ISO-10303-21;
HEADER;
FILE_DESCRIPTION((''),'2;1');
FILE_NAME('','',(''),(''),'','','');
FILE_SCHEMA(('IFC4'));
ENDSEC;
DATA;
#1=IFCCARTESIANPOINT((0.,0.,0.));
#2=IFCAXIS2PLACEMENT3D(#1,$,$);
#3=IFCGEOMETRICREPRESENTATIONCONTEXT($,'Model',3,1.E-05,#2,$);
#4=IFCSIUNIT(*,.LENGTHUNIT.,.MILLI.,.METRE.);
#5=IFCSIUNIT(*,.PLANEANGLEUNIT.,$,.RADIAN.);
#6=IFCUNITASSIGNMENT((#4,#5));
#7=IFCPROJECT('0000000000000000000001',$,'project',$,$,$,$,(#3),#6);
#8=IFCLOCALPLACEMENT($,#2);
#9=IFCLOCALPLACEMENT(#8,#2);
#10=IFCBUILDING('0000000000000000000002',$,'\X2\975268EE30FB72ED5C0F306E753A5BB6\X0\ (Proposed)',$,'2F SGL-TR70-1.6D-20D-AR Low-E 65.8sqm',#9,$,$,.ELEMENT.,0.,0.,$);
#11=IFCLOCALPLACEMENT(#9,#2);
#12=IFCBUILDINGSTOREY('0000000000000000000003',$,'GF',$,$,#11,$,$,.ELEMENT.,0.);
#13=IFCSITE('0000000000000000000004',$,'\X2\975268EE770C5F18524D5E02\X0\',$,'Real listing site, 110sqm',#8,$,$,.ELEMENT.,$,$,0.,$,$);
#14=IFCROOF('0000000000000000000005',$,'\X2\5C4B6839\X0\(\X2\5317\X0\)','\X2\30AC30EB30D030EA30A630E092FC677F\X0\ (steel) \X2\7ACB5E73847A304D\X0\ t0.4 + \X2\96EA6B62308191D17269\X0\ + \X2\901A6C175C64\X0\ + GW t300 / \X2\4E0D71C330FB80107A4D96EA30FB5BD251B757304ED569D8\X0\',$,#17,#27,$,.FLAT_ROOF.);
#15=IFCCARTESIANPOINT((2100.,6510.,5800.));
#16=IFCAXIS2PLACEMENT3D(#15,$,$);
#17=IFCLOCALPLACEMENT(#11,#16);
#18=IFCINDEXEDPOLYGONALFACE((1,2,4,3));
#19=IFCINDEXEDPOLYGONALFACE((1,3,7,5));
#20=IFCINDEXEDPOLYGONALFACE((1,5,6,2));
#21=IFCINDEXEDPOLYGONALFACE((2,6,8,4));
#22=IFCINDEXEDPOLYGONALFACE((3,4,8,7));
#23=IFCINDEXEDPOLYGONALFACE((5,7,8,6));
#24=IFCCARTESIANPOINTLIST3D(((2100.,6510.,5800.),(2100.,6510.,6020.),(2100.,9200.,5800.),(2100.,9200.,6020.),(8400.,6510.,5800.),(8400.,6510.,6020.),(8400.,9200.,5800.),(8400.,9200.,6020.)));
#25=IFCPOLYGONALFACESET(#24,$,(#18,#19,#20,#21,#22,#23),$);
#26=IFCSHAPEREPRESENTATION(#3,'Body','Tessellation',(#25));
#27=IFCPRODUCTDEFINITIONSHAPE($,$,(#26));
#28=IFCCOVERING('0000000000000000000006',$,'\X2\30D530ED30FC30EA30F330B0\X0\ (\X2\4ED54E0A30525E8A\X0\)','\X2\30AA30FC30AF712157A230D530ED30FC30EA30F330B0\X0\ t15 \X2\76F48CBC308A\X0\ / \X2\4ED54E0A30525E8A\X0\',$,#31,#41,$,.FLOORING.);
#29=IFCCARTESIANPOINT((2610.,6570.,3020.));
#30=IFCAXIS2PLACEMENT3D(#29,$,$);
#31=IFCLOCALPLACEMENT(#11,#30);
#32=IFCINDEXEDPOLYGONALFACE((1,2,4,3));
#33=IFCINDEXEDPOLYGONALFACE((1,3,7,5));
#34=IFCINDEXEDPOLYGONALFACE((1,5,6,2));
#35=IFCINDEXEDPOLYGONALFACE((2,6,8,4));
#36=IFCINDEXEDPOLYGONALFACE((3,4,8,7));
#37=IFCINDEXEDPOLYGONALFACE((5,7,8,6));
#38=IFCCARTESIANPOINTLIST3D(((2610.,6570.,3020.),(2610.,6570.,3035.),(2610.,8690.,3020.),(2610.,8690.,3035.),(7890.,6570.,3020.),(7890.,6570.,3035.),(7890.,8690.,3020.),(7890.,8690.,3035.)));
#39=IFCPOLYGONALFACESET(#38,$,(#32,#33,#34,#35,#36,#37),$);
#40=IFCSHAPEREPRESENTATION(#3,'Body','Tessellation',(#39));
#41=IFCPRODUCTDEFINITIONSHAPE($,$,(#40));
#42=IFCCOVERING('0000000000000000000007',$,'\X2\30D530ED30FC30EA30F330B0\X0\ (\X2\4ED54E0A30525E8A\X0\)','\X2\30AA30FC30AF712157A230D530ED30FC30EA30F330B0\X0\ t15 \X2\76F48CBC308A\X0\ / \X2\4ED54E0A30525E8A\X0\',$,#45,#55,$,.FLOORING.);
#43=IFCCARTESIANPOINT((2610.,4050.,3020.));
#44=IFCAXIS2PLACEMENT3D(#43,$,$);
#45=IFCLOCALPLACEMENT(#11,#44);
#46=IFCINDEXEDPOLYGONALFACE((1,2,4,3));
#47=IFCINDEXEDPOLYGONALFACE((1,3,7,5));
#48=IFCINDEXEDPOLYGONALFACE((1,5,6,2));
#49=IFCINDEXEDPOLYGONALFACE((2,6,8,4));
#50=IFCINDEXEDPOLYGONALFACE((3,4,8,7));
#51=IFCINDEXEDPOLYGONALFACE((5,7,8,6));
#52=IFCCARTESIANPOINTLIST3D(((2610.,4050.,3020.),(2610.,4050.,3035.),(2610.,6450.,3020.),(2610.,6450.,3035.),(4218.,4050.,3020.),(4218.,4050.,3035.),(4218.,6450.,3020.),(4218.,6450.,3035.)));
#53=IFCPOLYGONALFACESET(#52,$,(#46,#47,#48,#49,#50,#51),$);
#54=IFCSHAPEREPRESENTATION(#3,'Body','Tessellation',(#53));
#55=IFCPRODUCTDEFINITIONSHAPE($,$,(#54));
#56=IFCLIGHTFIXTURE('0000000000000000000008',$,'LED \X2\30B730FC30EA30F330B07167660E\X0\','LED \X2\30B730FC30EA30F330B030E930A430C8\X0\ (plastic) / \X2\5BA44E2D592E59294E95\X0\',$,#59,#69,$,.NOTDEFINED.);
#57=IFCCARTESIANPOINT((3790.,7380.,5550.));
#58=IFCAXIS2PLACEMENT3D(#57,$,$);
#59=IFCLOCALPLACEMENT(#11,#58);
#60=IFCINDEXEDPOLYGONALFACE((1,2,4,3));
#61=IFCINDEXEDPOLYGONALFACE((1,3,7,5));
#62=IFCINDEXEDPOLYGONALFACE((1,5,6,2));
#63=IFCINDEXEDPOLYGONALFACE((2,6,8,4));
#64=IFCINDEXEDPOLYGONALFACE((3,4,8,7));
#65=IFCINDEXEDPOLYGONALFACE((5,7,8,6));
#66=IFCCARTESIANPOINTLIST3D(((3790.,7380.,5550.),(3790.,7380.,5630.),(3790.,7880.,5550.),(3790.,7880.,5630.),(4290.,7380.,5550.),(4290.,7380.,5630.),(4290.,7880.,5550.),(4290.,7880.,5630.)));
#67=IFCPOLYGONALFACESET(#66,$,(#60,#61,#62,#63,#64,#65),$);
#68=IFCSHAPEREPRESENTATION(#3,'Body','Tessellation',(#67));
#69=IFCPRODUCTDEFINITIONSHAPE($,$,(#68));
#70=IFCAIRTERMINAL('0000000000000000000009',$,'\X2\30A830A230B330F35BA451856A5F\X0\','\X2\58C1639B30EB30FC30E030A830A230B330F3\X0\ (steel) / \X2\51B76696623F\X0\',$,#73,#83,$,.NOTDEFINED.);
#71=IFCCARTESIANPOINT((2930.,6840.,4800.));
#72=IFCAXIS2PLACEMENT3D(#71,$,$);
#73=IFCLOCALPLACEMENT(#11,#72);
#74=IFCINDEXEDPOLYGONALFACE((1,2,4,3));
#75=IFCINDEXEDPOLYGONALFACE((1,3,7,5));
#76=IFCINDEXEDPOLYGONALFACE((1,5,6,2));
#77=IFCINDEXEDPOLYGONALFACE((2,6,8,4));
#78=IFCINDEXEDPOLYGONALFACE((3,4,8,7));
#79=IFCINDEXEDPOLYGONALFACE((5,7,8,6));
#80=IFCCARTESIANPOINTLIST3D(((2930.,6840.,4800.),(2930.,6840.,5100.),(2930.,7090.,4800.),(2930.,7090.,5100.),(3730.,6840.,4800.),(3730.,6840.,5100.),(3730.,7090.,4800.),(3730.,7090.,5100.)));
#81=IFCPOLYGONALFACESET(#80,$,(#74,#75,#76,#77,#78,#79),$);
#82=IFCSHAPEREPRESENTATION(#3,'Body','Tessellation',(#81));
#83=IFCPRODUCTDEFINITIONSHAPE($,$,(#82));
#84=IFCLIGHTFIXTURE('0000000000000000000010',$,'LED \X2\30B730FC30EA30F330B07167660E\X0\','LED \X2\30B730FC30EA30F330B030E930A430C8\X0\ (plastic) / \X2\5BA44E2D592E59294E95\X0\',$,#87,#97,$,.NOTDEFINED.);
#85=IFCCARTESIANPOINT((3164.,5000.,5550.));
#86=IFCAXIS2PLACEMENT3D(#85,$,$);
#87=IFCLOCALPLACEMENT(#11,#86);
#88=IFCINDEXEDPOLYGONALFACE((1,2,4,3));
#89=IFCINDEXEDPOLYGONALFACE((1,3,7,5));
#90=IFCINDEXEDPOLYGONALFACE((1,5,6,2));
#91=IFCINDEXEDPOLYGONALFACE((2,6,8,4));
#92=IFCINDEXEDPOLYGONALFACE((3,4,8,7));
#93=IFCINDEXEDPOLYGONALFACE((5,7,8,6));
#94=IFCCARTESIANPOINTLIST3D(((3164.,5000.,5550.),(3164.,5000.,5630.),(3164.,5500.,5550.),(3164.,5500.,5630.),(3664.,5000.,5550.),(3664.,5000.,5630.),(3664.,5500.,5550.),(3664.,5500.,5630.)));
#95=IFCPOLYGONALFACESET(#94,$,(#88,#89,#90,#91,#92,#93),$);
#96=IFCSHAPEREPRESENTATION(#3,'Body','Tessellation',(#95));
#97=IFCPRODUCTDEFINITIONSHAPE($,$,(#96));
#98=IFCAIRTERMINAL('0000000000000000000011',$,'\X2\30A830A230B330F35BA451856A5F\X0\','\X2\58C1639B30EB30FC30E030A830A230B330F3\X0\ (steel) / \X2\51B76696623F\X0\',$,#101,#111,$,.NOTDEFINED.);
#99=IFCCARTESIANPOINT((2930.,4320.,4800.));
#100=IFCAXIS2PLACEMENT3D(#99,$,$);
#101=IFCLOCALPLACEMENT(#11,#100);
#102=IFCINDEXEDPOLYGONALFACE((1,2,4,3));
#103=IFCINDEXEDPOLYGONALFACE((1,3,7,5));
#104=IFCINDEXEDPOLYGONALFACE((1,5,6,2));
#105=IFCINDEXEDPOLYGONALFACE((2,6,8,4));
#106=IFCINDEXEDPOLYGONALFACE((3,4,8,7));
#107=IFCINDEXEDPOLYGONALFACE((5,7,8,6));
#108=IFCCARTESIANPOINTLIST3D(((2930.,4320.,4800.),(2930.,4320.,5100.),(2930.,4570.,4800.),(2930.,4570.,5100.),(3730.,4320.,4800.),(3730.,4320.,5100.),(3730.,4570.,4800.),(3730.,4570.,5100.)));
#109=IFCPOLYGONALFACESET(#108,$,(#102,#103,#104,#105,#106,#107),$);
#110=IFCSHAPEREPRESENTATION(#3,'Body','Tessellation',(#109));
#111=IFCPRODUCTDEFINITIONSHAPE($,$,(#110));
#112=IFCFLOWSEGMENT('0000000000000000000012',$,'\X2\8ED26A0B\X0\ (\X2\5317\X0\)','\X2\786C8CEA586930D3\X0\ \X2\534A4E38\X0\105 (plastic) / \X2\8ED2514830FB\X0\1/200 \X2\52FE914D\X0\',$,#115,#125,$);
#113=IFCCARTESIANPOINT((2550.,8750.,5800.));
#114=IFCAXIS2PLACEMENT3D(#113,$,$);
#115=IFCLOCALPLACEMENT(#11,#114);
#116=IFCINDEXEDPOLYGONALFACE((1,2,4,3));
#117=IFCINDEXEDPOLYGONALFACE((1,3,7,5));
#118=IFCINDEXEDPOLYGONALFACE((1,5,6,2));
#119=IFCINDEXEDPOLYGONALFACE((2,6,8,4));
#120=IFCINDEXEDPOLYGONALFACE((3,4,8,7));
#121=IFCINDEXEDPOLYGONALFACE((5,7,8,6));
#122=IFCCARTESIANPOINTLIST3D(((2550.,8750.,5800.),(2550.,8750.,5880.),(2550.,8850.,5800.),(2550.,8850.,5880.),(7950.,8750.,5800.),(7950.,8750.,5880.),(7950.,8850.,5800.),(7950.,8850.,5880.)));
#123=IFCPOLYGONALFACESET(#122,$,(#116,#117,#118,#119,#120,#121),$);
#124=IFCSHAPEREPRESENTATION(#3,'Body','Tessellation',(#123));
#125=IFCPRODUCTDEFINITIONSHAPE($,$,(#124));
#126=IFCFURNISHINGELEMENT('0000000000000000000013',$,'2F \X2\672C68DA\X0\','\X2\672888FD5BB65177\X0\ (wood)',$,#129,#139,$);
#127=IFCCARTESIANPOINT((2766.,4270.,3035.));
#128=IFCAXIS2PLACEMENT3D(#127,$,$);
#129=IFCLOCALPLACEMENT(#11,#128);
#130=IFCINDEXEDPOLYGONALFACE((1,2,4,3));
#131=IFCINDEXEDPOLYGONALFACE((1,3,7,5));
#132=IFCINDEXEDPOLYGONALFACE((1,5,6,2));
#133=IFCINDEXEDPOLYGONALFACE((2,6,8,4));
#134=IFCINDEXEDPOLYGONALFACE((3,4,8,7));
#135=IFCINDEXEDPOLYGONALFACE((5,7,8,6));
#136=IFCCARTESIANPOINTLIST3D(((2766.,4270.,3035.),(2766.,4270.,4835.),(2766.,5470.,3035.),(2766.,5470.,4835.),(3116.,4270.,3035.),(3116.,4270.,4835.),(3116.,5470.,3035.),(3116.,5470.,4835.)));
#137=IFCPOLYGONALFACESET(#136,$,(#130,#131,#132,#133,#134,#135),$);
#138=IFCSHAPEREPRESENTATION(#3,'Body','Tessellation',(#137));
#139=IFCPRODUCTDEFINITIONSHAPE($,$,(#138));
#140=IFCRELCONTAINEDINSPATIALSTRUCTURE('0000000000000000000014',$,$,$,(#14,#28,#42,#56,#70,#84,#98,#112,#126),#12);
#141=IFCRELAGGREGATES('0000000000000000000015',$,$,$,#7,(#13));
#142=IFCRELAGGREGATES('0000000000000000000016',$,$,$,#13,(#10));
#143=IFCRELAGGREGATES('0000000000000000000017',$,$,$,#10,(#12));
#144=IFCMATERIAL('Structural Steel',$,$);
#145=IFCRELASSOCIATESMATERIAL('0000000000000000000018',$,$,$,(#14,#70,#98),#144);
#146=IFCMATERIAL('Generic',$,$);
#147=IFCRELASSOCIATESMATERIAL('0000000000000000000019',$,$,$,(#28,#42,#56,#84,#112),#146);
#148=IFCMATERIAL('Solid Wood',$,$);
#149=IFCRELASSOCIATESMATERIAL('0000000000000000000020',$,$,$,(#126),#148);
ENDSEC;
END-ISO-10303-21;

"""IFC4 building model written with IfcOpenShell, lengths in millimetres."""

from ifc_helpers import new_model, si_unit, frame, frame_2d, origin, place, context, project, spatial, rectangle, extrude, material, element, save


model = new_model("IFC4")

# Units and contexts
model_context = context("Model", 3, precision=1e-05, world=origin())
ifc_project = project(units=[si_unit("LENGTHUNIT", "METRE", prefix="MILLI"), si_unit("PLANEANGLEUNIT", "RADIAN")], contexts=[model_context])

# Site, building, storey
site_placement = place(None, origin())
site = spatial("IfcSite", under=ifc_project, at=site_placement, Name="青森県弘前市", ObjectType="Real listing site, 110sqm", CompositionType="ELEMENT", RefElevation=0.0)
building_placement = place(site_placement, origin())
building = spatial("IfcBuilding", under=site, at=building_placement, Name="青森・狭小の町家 (Proposed)", ObjectType="2F SGL-TR70-1.6D-20D-AR Low-E 65.8sqm", CompositionType="ELEMENT", ElevationOfRefHeight=0.0, ElevationOfTerrain=0.0)
storey_placement = place(building_placement, origin())
storey = spatial("IfcBuildingStorey", under=building, at=storey_placement, Name="GF", CompositionType="ELEMENT", Elevation=0.0)

# Shared definitions
ifc_material_1 = material(Name="Solid Wood")

# Roof
ifc_material_2 = material(Name="Structural Steel")
for number, where, name in (
    (1, (2100.0, 6510.0, 5800.0), "屋根(北)"),
):
    element("IfcRoof", number, at=place(storey_placement, frame(where)), inside=storey, material=ifc_material_2, Name=name, Description="ガルバリウム鋼板 (steel) 立平葺き t0.4 + 雪止め金物 + 通気層 + GW t300 / 不燃・耐積雪・寒冷地仕様", PredefinedType="FLAT_ROOF", context=model_context, shape_type="SweptSolid", body=[
        extrude(rectangle(XDim=6300.0, YDim=2690.0, at=frame_2d((3150.0, 1345.0))), frame((2100.0, 6510.0, 5800.0)), (0.0, 0.0, 1.0), 220.0),
    ])

# Coverings
ifc_material_3 = material(Name="Generic")
covering_1_placement = place(storey_placement, frame((2610.0, 6570.0, 3020.0)))
element("IfcCovering", 2, at=covering_1_placement, inside=storey, material=ifc_material_3, Name="フローリング (仕上げ床)", Description="オーク無垢フローリング t15 直貼り / 仕上げ床", PredefinedType="FLOORING", context=model_context, shape_type="SweptSolid", body=[
    extrude(rectangle(XDim=5280.0, YDim=2120.0, at=frame_2d((2640.0, 1060.0))), frame((2610.0, 6570.0, 3020.0)), (0.0, 0.0, 1.0), 15.0),
])
covering_2_placement = place(storey_placement, frame((2610.0, 4050.0, 3020.0)))
element("IfcCovering", 3, at=covering_2_placement, inside=storey, material=ifc_material_3, Name="フローリング (仕上げ床)", Description="オーク無垢フローリング t15 直貼り / 仕上げ床", PredefinedType="FLOORING", context=model_context, shape_type="SweptSolid", body=[
    extrude(rectangle(XDim=1608.0, YDim=2400.0, at=frame_2d((804.0, 1200.0))), frame((2610.0, 4050.0, 3020.0)), (0.0, 0.0, 1.0), 15.0),
])

# Light fixture
light_fixture_1_placement = place(storey_placement, frame((3790.0, 7380.0, 5550.0)))
element("IfcLightFixture", 4, at=light_fixture_1_placement, inside=storey, material=ifc_material_3, Name="LED シーリング照明", Description="LED シーリングライト (plastic) / 室中央天井", PredefinedType="NOTDEFINED", context=model_context, shape_type="SweptSolid", body=[
    extrude(rectangle(XDim=500.0, YDim=500.0, at=frame_2d((250.0, 250.0))), frame((3790.0, 7380.0, 5550.0)), (0.0, 0.0, 1.0), 80.0),
])

# Air terminal
air_terminal_1_placement = place(storey_placement, frame((2930.0, 6840.0, 4800.0)))
element("IfcAirTerminal", 5, at=air_terminal_1_placement, inside=storey, material=ifc_material_2, Name="エアコン室内機", Description="壁掛ルームエアコン (steel) / 冷暖房", PredefinedType="NOTDEFINED", context=model_context, shape_type="SweptSolid", body=[
    extrude(rectangle(XDim=800.0, YDim=250.0, at=frame_2d((400.0, 125.0))), frame((2930.0, 6840.0, 4800.0)), (0.0, 0.0, 1.0), 300.0),
])

# Light fixture
light_fixture_2_placement = place(storey_placement, frame((3164.0, 5000.0, 5550.0)))
element("IfcLightFixture", 6, at=light_fixture_2_placement, inside=storey, material=ifc_material_3, Name="LED シーリング照明", Description="LED シーリングライト (plastic) / 室中央天井", PredefinedType="NOTDEFINED", context=model_context, shape_type="SweptSolid", body=[
    extrude(rectangle(XDim=500.0, YDim=500.0, at=frame_2d((250.0, 250.0))), frame((3164.0, 5000.0, 5550.0)), (0.0, 0.0, 1.0), 80.0),
])

# Air terminal
air_terminal_2_placement = place(storey_placement, frame((2930.0, 4320.0, 4800.0)))
element("IfcAirTerminal", 7, at=air_terminal_2_placement, inside=storey, material=ifc_material_2, Name="エアコン室内機", Description="壁掛ルームエアコン (steel) / 冷暖房", PredefinedType="NOTDEFINED", context=model_context, shape_type="SweptSolid", body=[
    extrude(rectangle(XDim=800.0, YDim=250.0, at=frame_2d((400.0, 125.0))), frame((2930.0, 4320.0, 4800.0)), (0.0, 0.0, 1.0), 300.0),
])

# Flow segment
flow_segment_placement = place(storey_placement, frame((2550.0, 8750.0, 5800.0)))
element("IfcFlowSegment", 8, at=flow_segment_placement, inside=storey, material=ifc_material_3, Name="軒樋 (北)", Description="硬質塩ビ 半丸105 (plastic) / 軒先・1/200 勾配", context=model_context, shape_type="SweptSolid", body=[
    extrude(rectangle(XDim=5400.0, YDim=100.0, at=frame_2d((2700.0, 50.0))), frame((2550.0, 8750.0, 5800.0)), (0.0, 0.0, 1.0), 80.0),
])

# Furnishing element
furnishing_placement = place(storey_placement, frame((2766.0, 4270.0, 3035.0)))
element("IfcFurnishingElement", 9, at=furnishing_placement, inside=storey, material=ifc_material_1, Name="2F 本棚", Description="木製家具 (wood)", context=model_context, shape_type="SweptSolid", body=[
    extrude(rectangle(XDim=350.0, YDim=1200.0, at=frame_2d((175.0, 600.0))), frame((2766.0, 4270.0, 3035.0)), (0.0, 0.0, 1.0), 1800.0),
])

save(model, "model.ifc")
